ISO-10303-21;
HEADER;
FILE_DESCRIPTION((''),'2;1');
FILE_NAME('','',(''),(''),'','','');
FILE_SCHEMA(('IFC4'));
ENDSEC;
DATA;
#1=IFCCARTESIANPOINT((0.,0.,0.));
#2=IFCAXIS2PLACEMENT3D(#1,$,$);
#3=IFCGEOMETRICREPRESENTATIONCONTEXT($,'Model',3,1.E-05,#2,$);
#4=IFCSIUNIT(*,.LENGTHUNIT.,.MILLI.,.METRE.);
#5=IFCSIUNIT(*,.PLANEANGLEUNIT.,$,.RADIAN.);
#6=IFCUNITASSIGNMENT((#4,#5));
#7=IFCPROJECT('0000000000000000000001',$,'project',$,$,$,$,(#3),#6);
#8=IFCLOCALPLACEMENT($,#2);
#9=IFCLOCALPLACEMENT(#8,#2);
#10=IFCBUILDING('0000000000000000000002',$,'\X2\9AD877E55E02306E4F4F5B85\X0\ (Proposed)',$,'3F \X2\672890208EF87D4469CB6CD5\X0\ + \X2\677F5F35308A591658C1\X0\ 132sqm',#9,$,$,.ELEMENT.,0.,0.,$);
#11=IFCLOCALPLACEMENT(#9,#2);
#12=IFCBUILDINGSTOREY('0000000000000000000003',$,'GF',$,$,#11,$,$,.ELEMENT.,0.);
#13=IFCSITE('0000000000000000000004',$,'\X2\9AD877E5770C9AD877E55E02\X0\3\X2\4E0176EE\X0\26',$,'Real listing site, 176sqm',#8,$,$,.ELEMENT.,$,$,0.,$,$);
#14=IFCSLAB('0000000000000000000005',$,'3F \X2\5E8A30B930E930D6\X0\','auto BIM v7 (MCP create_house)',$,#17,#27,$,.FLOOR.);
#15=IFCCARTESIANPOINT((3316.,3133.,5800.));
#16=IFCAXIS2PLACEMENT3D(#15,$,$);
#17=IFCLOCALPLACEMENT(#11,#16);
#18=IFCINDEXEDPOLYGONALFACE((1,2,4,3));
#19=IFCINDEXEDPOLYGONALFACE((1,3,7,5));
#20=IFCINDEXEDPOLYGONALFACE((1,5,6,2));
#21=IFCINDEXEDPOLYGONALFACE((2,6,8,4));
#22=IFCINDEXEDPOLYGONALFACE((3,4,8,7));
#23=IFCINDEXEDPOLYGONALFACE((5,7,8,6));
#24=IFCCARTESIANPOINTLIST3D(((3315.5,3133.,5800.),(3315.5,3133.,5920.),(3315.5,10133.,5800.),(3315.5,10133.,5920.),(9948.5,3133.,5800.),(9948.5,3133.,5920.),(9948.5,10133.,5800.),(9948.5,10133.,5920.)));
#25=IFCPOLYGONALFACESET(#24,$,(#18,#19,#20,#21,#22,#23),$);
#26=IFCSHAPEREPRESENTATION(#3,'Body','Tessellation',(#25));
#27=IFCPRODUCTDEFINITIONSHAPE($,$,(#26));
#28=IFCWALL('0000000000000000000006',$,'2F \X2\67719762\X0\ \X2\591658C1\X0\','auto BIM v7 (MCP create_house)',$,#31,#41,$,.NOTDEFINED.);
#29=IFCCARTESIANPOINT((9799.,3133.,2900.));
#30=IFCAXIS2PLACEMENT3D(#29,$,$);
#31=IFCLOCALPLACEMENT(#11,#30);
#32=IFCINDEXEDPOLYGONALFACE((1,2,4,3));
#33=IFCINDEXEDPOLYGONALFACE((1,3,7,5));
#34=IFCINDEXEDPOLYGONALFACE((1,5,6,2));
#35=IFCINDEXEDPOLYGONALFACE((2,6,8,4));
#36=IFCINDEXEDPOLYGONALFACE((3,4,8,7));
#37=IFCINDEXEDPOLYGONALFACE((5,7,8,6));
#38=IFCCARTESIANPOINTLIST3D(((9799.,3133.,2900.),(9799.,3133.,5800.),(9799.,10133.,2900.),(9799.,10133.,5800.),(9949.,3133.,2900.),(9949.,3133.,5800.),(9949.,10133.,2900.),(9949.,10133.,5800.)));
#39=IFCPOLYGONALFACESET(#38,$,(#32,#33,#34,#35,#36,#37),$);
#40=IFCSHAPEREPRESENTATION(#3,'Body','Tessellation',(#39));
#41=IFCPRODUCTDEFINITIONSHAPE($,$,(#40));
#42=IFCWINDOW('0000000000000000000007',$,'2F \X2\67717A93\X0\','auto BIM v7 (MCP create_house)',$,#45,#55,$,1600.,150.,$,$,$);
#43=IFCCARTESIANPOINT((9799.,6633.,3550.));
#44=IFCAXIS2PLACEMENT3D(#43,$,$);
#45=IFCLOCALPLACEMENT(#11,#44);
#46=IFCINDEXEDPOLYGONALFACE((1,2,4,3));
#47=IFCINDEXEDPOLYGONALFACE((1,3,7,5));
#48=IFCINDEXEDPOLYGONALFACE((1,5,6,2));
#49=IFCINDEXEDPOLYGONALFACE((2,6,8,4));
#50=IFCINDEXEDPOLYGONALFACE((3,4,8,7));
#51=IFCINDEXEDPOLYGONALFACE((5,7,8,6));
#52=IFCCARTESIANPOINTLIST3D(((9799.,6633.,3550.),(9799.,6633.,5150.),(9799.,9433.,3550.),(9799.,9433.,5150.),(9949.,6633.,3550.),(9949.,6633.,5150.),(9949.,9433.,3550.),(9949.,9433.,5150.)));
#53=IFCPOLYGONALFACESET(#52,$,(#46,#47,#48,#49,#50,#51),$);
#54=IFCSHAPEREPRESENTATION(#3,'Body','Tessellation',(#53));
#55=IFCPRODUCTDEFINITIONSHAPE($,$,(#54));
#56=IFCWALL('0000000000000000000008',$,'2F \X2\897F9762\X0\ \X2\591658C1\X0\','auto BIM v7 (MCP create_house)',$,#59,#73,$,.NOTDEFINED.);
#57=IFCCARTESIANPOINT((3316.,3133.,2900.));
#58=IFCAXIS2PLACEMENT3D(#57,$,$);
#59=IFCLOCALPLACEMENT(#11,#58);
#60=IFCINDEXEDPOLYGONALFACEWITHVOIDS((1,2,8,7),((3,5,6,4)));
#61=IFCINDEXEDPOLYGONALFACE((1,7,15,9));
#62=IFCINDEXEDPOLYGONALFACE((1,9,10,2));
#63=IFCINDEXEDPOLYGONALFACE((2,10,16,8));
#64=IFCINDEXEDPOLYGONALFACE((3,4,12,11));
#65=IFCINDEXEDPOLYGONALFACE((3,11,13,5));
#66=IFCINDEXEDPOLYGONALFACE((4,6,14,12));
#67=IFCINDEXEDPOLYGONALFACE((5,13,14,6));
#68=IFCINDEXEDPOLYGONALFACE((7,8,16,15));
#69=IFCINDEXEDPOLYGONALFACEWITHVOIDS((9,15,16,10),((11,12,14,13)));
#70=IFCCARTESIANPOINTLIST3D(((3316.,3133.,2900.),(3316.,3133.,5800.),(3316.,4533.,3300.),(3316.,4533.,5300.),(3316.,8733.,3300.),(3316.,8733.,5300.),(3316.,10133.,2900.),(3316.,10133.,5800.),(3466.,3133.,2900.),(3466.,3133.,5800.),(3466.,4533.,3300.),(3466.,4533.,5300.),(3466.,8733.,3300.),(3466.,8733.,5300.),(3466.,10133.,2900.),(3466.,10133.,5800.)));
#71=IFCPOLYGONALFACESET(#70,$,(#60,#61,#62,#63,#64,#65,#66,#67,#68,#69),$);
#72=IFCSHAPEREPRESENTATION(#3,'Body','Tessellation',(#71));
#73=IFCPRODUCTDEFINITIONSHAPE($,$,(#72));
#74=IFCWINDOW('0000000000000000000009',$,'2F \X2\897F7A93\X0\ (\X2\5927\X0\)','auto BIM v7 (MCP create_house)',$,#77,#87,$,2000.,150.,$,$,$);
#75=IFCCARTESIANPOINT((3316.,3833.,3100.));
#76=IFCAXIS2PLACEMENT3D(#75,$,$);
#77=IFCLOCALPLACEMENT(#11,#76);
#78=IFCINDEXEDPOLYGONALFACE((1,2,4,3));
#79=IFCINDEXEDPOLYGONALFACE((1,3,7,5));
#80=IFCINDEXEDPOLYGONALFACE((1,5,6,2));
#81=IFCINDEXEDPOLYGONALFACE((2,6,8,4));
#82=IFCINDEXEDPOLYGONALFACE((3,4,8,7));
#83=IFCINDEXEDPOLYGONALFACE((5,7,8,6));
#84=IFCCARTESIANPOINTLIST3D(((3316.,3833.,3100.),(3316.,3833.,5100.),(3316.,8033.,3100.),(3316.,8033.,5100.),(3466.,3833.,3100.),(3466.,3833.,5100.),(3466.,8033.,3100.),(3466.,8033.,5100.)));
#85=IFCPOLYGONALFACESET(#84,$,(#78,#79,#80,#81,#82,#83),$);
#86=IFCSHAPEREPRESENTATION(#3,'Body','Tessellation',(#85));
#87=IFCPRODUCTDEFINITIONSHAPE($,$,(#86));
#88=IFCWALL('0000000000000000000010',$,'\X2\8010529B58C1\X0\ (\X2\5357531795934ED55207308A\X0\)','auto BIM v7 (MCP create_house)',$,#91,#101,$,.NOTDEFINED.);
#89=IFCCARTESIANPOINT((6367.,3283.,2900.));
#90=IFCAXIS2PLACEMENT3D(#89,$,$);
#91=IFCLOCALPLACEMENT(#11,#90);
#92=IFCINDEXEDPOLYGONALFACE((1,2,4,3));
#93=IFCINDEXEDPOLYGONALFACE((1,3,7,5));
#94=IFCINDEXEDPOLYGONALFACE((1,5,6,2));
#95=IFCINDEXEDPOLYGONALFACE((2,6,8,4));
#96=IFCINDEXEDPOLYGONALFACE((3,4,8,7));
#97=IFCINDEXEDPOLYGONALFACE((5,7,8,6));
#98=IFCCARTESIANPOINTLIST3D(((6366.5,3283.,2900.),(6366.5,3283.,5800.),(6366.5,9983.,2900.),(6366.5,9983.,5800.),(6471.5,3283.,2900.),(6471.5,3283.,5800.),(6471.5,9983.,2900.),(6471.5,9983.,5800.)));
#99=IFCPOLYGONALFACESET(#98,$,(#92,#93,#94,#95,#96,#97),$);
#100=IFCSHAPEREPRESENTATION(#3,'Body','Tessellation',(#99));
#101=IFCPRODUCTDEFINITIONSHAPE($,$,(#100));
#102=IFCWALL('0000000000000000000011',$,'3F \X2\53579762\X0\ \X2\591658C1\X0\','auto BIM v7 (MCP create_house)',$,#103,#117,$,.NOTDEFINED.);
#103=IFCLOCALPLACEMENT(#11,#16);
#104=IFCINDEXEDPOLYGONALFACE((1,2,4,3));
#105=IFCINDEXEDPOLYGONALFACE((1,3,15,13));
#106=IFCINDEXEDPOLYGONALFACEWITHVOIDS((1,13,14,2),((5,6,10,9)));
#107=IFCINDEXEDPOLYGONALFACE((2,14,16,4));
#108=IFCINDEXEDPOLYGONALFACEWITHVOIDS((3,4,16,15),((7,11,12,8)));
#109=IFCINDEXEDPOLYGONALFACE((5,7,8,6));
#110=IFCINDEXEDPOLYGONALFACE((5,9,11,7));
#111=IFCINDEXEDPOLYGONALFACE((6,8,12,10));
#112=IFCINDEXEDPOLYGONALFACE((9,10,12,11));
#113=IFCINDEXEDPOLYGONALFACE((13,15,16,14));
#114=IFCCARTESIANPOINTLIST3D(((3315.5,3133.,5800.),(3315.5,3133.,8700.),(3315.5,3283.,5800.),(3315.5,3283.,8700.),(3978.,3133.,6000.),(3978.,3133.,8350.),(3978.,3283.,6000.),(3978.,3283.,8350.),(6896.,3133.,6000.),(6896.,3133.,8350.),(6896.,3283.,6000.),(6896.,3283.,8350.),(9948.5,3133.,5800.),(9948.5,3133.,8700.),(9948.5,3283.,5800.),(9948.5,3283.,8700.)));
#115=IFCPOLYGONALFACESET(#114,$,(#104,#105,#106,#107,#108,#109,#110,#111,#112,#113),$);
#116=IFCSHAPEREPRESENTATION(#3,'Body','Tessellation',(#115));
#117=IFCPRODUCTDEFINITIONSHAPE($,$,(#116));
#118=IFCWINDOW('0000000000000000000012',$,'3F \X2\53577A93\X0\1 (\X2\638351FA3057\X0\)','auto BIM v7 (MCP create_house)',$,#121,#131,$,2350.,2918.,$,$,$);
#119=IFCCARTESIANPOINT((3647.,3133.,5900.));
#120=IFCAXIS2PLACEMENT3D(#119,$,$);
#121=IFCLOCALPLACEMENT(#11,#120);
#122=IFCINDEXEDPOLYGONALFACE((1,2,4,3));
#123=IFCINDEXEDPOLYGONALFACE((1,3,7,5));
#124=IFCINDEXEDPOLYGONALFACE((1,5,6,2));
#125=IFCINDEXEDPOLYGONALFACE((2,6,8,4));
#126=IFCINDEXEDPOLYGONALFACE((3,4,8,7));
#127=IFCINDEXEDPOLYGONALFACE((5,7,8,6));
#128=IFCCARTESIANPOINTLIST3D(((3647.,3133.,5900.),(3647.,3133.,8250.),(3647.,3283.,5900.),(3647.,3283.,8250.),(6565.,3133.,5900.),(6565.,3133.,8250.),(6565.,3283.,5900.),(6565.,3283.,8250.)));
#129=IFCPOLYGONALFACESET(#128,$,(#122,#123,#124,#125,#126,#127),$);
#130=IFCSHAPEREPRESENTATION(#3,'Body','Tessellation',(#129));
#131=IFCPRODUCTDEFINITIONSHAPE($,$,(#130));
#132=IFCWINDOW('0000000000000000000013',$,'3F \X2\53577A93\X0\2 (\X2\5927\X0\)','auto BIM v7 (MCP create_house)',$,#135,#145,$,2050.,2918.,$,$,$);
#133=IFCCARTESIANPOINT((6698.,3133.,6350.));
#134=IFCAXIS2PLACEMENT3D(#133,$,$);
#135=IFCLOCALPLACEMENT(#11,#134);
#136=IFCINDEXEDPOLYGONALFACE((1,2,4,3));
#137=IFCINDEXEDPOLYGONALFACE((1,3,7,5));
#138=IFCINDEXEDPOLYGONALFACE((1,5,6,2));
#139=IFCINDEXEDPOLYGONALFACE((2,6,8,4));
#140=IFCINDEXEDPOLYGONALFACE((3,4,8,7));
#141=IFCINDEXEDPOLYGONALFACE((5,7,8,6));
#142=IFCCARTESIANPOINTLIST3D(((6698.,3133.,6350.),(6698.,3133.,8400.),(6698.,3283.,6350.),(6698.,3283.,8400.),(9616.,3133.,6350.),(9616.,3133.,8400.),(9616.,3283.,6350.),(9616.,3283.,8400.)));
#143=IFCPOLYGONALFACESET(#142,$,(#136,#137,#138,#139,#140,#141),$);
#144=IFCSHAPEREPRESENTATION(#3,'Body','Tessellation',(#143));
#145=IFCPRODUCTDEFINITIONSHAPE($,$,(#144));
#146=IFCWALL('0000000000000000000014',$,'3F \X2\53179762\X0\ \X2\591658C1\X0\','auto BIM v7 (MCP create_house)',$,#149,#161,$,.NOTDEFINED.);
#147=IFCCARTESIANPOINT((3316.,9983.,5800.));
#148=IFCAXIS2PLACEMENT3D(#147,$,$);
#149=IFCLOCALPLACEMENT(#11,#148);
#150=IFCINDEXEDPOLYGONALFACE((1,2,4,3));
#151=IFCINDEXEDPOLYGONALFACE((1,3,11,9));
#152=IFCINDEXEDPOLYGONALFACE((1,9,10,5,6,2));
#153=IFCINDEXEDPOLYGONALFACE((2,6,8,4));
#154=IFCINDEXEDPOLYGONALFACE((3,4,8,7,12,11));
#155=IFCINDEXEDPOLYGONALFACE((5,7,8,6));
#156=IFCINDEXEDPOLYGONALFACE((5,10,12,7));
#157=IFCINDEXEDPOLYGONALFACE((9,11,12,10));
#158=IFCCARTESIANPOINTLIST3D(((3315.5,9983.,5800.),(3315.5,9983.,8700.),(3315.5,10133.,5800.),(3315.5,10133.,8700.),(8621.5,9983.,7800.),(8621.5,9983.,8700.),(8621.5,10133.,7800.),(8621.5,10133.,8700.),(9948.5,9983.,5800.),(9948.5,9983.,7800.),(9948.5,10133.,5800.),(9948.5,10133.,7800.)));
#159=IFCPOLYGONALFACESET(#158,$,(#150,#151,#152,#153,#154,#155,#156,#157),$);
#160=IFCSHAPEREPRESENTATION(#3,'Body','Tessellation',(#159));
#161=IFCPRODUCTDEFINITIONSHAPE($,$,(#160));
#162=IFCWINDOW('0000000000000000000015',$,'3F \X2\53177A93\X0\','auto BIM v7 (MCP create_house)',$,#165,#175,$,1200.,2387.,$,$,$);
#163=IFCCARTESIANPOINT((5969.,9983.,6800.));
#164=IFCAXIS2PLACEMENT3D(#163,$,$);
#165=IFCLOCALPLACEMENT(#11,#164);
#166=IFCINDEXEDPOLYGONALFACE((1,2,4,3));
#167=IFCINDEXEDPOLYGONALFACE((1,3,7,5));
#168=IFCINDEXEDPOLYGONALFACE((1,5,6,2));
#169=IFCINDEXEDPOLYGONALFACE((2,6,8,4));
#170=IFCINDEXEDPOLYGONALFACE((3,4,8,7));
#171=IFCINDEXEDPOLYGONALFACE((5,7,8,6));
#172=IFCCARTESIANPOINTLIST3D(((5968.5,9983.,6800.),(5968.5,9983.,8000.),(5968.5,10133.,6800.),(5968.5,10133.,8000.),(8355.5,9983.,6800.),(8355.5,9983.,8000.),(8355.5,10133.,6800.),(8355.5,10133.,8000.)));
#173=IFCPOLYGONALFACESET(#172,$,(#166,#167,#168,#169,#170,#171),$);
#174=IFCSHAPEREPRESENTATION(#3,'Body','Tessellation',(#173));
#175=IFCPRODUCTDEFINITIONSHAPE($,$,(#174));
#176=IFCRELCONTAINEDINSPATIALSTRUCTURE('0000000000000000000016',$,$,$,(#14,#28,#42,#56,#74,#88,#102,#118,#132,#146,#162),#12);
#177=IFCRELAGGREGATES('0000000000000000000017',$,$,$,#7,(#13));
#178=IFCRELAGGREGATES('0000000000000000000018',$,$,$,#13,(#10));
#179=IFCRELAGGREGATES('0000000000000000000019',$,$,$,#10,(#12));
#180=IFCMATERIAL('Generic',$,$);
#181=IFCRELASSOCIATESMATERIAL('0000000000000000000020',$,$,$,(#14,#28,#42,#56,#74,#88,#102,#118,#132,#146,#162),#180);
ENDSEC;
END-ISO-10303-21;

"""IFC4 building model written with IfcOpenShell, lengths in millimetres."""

from ifc_helpers import new_model, si_unit, frame, frame_2d, origin, place, context, project, spatial, rectangle, extrude, material, element, fill, save


model = new_model("IFC4")

# Units and contexts
model_context = context("Model", 3, precision=1e-05, world=origin())
ifc_project = project(units=[si_unit("LENGTHUNIT", "METRE", prefix="MILLI"), si_unit("PLANEANGLEUNIT", "RADIAN")], contexts=[model_context])

# Site, building, storey
site_placement = place(None, origin())
site = spatial("IfcSite", under=ifc_project, at=site_placement, Name="高知県高知市3丁目26", ObjectType="Real listing site, 176sqm", CompositionType="ELEMENT", RefElevation=0.0)
building_placement = place(site_placement, origin())
building = spatial("IfcBuilding", under=site, at=building_placement, Name="高知市の住宅 (Proposed)", ObjectType="3F 木造軸組構法 + 板張り外壁 132sqm", CompositionType="ELEMENT", ElevationOfRefHeight=0.0, ElevationOfTerrain=0.0)
storey_placement = place(building_placement, origin())
storey = spatial("IfcBuildingStorey", under=building, at=storey_placement, Name="GF", CompositionType="ELEMENT", Elevation=0.0)

# Slab
ifc_material = material(Name="Generic")
slab_placement = place(storey_placement, frame((3316.0, 3133.0, 5800.0)))
element("IfcSlab", 1, at=slab_placement, inside=storey, material=ifc_material, Name="3F 床スラブ", Description="auto BIM v7 (MCP create_house)", PredefinedType="FLOOR", context=model_context, shape_type="SweptSolid", body=[
    extrude(rectangle(XDim=6633.0, YDim=7000.0, at=frame_2d((3316.0, 3500.0))), frame((3316.0, 3133.0, 5800.0)), (0.0, 0.0, 1.0), 120.0),
])

# Walls, openings, windows
wall_1_placement = place(storey_placement, frame((9799.0, 3133.0, 2900.0)))
wall_1 = element("IfcWall", 2, at=wall_1_placement, inside=storey, material=ifc_material, Name="2F 東面 外壁", Description="auto BIM v7 (MCP create_house)", PredefinedType="NOTDEFINED", context=model_context, shape_type="SweptSolid", body=[
    extrude(rectangle(XDim=150.0, YDim=7000.0, at=frame_2d((75.0, 3500.0))), frame((9799.0, 3133.0, 2900.0)), (0.0, 0.0, 1.0), 2900.0),
])
opening_1_placement = place(storey_placement, frame((9799.0, 6633.0, 3550.0)))
opening_1 = element("IfcOpeningElement", 3, at=opening_1_placement, cuts=wall_1, PredefinedType="NOTDEFINED", context=model_context, shape_type="SweptSolid", body=[
    extrude(rectangle(XDim=150.0, YDim=2800.0, at=frame_2d((75.0, 1400.0))), frame((9799.0, 6633.0, 3550.0)), (0.0, 0.0, 1.0), 1600.0),
])
window_1_placement = place(storey_placement, frame((9799.0, 6633.0, 3550.0)))
window_1 = element("IfcWindow", 4, at=window_1_placement, inside=storey, material=ifc_material, Name="2F 東窓", Description="auto BIM v7 (MCP create_house)", OverallHeight=1600.0, OverallWidth=150.0, context=model_context, shape_type="SweptSolid", body=[
    extrude(rectangle(XDim=150.0, YDim=2800.0, at=frame_2d((75.0, 1400.0))), frame((9799.0, 6633.0, 3550.0)), (0.0, 0.0, 1.0), 1600.0),
])
fill(opening_1, window_1)
wall_2_placement = place(storey_placement, frame((3316.0, 3133.0, 2900.0)))
wall_2 = element("IfcWall", 5, at=wall_2_placement, inside=storey, material=ifc_material, Name="2F 西面 外壁", Description="auto BIM v7 (MCP create_house)", PredefinedType="NOTDEFINED", context=model_context, shape_type="SweptSolid", body=[
    extrude(rectangle(XDim=150.0, YDim=7000.0, at=frame_2d((75.0, 3500.0))), frame((3316.0, 3133.0, 2900.0)), (0.0, 0.0, 1.0), 2900.0),
])
opening_2_placement = place(storey_placement, frame((3316.0, 3833.0, 3100.0)))
opening_2 = element("IfcOpeningElement", 6, at=opening_2_placement, cuts=wall_2, PredefinedType="NOTDEFINED", context=model_context, shape_type="SweptSolid", body=[
    extrude(rectangle(XDim=150.0, YDim=4200.0, at=frame_2d((75.0, 2100.0))), frame((3316.0, 3833.0, 3100.0)), (0.0, 0.0, 1.0), 2000.0),
])
window_2_placement = place(storey_placement, frame((3316.0, 3833.0, 3100.0)))
window_2 = element("IfcWindow", 7, at=window_2_placement, inside=storey, material=ifc_material, Name="2F 西窓 (大)", Description="auto BIM v7 (MCP create_house)", OverallHeight=2000.0, OverallWidth=150.0, context=model_context, shape_type="SweptSolid", body=[
    extrude(rectangle(XDim=150.0, YDim=4200.0, at=frame_2d((75.0, 2100.0))), frame((3316.0, 3833.0, 3100.0)), (0.0, 0.0, 1.0), 2000.0),
])
fill(opening_2, window_2)

# Wall
wall_3_placement = place(storey_placement, frame((6367.0, 3283.0, 2900.0)))
element("IfcWall", 8, at=wall_3_placement, inside=storey, material=ifc_material, Name="耐力壁 (南北間仕切り)", Description="auto BIM v7 (MCP create_house)", PredefinedType="NOTDEFINED", context=model_context, shape_type="SweptSolid", body=[
    extrude(rectangle(XDim=105.0, YDim=6700.0, at=frame_2d((52.0, 3350.0))), frame((6367.0, 3283.0, 2900.0)), (0.0, 0.0, 1.0), 2900.0),
])

# Wall, openings, windows
wall_4_placement = place(storey_placement, frame((3316.0, 3133.0, 5800.0)))
wall_4 = element("IfcWall", 9, at=wall_4_placement, inside=storey, material=ifc_material, Name="3F 南面 外壁", Description="auto BIM v7 (MCP create_house)", PredefinedType="NOTDEFINED", context=model_context, shape_type="SweptSolid", body=[
    extrude(rectangle(XDim=6633.0, YDim=150.0, at=frame_2d((3316.0, 75.0))), frame((3316.0, 3133.0, 5800.0)), (0.0, 0.0, 1.0), 2900.0),
])
opening_3_placement = place(storey_placement, frame((3647.0, 3133.0, 5900.0)))
opening_3 = element("IfcOpeningElement", 10, at=opening_3_placement, cuts=wall_4, PredefinedType="NOTDEFINED", context=model_context, shape_type="SweptSolid", body=[
    extrude(rectangle(XDim=2918.0, YDim=150.0, at=frame_2d((1459.0, 75.0))), frame((3647.0, 3133.0, 5900.0)), (0.0, 0.0, 1.0), 2350.0),
])
opening_4_placement = place(storey_placement, frame((6698.0, 3133.0, 6350.0)))
opening_4 = element("IfcOpeningElement", 11, at=opening_4_placement, cuts=wall_4, PredefinedType="NOTDEFINED", context=model_context, shape_type="SweptSolid", body=[
    extrude(rectangle(XDim=2918.0, YDim=150.0, at=frame_2d((1459.0, 75.0))), frame((6698.0, 3133.0, 6350.0)), (0.0, 0.0, 1.0), 2050.0),
])
window_3_placement = place(storey_placement, frame((3647.0, 3133.0, 5900.0)))
window_3 = element("IfcWindow", 12, at=window_3_placement, inside=storey, material=ifc_material, Name="3F 南窓1 (掃出し)", Description="auto BIM v7 (MCP create_house)", OverallHeight=2350.0, OverallWidth=2918.0, context=model_context, shape_type="SweptSolid", body=[
    extrude(rectangle(XDim=2918.0, YDim=150.0, at=frame_2d((1459.0, 75.0))), frame((3647.0, 3133.0, 5900.0)), (0.0, 0.0, 1.0), 2350.0),
])
fill(opening_3, window_3)
window_4_placement = place(storey_placement, frame((6698.0, 3133.0, 6350.0)))
window_4 = element("IfcWindow", 13, at=window_4_placement, inside=storey, material=ifc_material, Name="3F 南窓2 (大)", Description="auto BIM v7 (MCP create_house)", OverallHeight=2050.0, OverallWidth=2918.0, context=model_context, shape_type="SweptSolid", body=[
    extrude(rectangle(XDim=2918.0, YDim=150.0, at=frame_2d((1459.0, 75.0))), frame((6698.0, 3133.0, 6350.0)), (0.0, 0.0, 1.0), 2050.0),
])
fill(opening_4, window_4)

# Wall, opening, window
wall_5_placement = place(storey_placement, frame((3316.0, 9983.0, 5800.0)))
wall_5 = element("IfcWall", 14, at=wall_5_placement, inside=storey, material=ifc_material, Name="3F 北面 外壁", Description="auto BIM v7 (MCP create_house)", PredefinedType="NOTDEFINED", context=model_context, shape_type="SweptSolid", body=[
    extrude(rectangle(XDim=6633.0, YDim=150.0, at=frame_2d((3316.0, 75.0))), frame((3316.0, 9983.0, 5800.0)), (0.0, 0.0, 1.0), 2900.0),
])
opening_5_placement = place(storey_placement, frame((5969.0, 9983.0, 6800.0)))
opening_5 = element("IfcOpeningElement", 15, at=opening_5_placement, cuts=wall_5, PredefinedType="NOTDEFINED", context=model_context, shape_type="SweptSolid", body=[
    extrude(rectangle(XDim=2387.0, YDim=150.0, at=frame_2d((1193.0, 75.0))), frame((5969.0, 9983.0, 6800.0)), (0.0, 0.0, 1.0), 1200.0),
])
window_5_placement = place(storey_placement, frame((5969.0, 9983.0, 6800.0)))
window_5 = element("IfcWindow", 16, at=window_5_placement, inside=storey, material=ifc_material, Name="3F 北窓", Description="auto BIM v7 (MCP create_house)", OverallHeight=1200.0, OverallWidth=2387.0, context=model_context, shape_type="SweptSolid", body=[
    extrude(rectangle(XDim=2387.0, YDim=150.0, at=frame_2d((1193.0, 75.0))), frame((5969.0, 9983.0, 6800.0)), (0.0, 0.0, 1.0), 1200.0),
])
fill(opening_5, window_5)

save(model, "model.ifc")
